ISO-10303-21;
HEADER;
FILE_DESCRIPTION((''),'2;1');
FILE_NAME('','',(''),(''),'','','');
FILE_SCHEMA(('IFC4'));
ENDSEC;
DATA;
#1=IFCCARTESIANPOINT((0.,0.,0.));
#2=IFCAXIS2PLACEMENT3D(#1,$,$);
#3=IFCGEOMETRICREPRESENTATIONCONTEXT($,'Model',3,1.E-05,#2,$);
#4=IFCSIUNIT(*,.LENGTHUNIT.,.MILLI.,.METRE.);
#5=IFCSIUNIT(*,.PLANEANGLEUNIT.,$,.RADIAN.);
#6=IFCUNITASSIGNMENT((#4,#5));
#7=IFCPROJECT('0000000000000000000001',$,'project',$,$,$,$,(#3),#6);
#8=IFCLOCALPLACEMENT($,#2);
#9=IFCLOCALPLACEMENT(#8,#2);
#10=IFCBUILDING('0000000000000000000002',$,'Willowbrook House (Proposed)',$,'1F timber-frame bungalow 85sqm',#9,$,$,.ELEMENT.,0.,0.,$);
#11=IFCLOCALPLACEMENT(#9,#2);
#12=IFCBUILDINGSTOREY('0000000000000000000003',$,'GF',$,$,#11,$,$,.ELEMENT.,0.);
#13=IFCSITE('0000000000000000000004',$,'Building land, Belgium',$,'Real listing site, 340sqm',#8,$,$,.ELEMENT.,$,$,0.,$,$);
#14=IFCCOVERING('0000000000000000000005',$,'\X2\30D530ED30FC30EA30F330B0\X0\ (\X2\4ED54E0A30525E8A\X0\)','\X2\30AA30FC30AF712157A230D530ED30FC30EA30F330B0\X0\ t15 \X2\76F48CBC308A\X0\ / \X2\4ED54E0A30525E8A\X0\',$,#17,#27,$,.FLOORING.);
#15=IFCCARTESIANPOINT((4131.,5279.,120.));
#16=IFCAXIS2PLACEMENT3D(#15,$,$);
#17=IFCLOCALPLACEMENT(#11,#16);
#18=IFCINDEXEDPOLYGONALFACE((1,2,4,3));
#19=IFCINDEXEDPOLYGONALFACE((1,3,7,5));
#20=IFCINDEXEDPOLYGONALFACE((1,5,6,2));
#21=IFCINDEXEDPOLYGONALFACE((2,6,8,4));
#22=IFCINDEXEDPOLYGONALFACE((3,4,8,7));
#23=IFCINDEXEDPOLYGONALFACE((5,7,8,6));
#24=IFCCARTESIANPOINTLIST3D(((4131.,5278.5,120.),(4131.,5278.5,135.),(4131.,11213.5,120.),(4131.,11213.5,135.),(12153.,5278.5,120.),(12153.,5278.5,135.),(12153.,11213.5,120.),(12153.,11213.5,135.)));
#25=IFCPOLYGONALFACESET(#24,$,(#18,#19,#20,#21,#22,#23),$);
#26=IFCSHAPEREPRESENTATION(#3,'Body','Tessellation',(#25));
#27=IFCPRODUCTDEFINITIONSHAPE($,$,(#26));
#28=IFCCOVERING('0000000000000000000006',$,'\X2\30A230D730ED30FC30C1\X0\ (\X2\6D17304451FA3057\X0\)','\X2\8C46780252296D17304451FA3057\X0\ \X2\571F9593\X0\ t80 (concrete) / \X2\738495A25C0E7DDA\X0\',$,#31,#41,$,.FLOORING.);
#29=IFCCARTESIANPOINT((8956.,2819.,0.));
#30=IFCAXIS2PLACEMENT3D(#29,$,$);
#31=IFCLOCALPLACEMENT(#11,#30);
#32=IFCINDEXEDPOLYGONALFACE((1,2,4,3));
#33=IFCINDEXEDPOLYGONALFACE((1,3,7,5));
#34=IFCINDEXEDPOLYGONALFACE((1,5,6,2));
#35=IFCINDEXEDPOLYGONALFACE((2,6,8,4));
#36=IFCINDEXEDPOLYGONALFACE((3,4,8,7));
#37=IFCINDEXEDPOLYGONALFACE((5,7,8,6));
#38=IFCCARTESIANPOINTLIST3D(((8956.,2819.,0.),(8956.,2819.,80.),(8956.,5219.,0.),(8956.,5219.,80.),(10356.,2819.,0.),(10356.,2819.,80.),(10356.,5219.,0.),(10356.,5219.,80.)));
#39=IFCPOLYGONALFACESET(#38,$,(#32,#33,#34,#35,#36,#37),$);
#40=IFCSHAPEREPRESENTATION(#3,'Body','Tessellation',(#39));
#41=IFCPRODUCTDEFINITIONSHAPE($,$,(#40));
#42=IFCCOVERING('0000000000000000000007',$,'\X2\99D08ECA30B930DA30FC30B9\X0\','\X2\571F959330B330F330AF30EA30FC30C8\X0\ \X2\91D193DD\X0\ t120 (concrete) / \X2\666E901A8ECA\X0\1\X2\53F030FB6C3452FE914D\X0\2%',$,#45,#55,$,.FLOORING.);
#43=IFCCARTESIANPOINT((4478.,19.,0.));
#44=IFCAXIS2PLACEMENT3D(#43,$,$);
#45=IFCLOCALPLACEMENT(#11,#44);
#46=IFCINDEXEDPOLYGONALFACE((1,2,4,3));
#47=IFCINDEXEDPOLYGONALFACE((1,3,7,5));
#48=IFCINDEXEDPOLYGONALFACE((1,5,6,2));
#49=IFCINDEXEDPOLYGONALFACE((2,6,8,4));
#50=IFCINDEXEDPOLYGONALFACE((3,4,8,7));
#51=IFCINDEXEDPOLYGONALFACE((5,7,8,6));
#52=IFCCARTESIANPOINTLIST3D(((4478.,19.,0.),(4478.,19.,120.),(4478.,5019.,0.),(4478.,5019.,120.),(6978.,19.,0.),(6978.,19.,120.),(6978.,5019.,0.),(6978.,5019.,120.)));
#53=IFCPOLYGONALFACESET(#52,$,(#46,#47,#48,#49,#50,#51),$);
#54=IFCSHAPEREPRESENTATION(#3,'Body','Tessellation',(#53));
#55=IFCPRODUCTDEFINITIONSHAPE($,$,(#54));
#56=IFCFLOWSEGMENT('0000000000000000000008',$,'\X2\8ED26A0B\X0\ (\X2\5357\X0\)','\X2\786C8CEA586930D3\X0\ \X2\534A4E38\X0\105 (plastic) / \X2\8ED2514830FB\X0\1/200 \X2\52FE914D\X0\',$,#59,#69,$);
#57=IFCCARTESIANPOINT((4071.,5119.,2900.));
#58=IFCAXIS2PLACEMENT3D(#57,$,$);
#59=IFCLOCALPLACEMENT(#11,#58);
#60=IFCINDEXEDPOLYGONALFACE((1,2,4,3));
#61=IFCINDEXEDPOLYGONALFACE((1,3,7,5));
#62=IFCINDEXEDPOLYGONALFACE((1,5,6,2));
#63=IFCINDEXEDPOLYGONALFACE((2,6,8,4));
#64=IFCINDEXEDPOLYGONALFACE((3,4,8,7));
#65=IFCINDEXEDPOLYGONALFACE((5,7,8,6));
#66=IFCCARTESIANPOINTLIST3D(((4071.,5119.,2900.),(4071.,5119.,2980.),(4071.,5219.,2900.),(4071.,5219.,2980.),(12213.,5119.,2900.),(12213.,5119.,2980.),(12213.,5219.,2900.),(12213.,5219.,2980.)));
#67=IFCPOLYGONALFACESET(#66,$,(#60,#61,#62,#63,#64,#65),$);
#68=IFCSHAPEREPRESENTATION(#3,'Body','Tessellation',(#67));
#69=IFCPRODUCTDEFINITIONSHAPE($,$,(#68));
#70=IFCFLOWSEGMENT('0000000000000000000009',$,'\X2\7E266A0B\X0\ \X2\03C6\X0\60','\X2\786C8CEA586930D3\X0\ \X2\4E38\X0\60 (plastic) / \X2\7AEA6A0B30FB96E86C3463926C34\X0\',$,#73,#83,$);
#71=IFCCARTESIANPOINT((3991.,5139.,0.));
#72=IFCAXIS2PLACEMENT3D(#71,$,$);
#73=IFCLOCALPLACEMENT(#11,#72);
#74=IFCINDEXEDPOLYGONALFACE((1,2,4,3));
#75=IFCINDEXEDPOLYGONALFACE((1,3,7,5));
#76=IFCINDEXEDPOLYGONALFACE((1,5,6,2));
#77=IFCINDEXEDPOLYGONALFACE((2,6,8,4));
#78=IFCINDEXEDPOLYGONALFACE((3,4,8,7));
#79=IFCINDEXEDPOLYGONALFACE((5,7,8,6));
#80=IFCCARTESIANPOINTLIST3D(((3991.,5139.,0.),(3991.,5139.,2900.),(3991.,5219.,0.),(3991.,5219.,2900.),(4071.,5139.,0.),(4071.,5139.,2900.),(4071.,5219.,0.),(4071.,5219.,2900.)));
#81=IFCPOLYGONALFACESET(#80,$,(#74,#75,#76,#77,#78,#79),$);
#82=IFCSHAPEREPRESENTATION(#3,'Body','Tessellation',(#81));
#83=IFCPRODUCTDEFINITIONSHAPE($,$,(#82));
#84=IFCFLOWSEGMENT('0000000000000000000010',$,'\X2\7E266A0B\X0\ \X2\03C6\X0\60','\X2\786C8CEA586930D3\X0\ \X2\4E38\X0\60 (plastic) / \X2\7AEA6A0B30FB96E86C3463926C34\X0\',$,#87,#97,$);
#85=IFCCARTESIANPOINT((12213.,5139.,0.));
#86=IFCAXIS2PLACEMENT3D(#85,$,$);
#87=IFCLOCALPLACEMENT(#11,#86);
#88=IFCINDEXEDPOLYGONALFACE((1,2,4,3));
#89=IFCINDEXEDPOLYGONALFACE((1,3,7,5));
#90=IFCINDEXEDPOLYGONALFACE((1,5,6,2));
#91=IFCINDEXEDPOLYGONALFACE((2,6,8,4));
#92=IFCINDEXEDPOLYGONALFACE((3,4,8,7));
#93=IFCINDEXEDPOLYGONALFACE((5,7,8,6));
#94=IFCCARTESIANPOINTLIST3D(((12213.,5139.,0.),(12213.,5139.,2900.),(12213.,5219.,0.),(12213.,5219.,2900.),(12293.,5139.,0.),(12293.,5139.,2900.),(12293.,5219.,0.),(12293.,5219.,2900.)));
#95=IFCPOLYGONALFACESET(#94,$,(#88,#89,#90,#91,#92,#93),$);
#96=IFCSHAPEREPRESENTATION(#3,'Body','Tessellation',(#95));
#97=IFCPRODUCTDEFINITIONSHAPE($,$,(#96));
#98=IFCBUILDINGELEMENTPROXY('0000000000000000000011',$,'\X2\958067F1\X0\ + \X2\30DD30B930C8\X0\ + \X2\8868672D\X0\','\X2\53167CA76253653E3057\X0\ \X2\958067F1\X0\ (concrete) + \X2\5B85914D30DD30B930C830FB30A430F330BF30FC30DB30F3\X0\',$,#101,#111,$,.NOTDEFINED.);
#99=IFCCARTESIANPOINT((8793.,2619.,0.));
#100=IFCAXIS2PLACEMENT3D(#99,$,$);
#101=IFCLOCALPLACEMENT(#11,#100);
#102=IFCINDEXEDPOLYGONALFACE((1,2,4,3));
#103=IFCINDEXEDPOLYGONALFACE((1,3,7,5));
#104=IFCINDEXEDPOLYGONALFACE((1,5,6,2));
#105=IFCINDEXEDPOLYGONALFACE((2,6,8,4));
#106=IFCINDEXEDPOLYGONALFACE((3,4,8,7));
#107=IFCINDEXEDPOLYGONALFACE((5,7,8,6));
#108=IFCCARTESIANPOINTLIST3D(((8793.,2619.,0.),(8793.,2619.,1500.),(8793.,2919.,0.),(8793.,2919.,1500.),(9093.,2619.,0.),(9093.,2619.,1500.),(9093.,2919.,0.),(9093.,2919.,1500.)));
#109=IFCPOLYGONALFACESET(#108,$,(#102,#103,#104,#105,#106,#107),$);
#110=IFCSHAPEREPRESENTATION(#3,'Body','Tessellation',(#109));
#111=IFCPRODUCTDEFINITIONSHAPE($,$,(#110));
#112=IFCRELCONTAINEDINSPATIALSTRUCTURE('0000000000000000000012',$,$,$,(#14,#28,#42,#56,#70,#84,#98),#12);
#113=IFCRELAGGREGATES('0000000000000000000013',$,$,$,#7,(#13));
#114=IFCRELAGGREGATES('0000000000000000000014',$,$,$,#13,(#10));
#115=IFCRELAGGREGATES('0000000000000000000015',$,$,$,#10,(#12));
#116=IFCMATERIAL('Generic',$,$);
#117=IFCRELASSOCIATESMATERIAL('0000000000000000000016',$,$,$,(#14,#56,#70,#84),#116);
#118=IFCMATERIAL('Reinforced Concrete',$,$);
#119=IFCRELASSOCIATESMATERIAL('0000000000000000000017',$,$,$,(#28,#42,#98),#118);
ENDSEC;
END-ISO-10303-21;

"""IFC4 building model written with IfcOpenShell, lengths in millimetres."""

from ifc_helpers import new_model, si_unit, frame, frame_2d, origin, place, context, project, spatial, rectangle, extrude, material, element, save


model = new_model("IFC4")

# Units and contexts
model_context = context("Model", 3, precision=1e-05, world=origin())
ifc_project = project(units=[si_unit("LENGTHUNIT", "METRE", prefix="MILLI"), si_unit("PLANEANGLEUNIT", "RADIAN")], contexts=[model_context])

# Site, building, storey
site_placement = place(None, origin())
site = spatial("IfcSite", under=ifc_project, at=site_placement, Name="Building land, Belgium", ObjectType="Real listing site, 340sqm", CompositionType="ELEMENT", RefElevation=0.0)
building_placement = place(site_placement, origin())
building = spatial("IfcBuilding", under=site, at=building_placement, Name="Willowbrook House (Proposed)", ObjectType="1F timber-frame bungalow 85sqm", CompositionType="ELEMENT", ElevationOfRefHeight=0.0, ElevationOfTerrain=0.0)
storey_placement = place(building_placement, origin())
storey = spatial("IfcBuildingStorey", under=building, at=storey_placement, Name="GF", CompositionType="ELEMENT", Elevation=0.0)

# Shared definitions
ifc_material_1 = material(Name="Reinforced Concrete")

# Coverings
ifc_material_2 = material(Name="Generic")
covering_1_placement = place(storey_placement, frame((4131.0, 5279.0, 120.0)))
element("IfcCovering", 1, at=covering_1_placement, inside=storey, material=ifc_material_2, Name="フローリング (仕上げ床)", Description="オーク無垢フローリング t15 直貼り / 仕上げ床", PredefinedType="FLOORING", context=model_context, shape_type="SweptSolid", body=[
    extrude(rectangle(XDim=8022.0, YDim=5935.0, at=frame_2d((4011.0, 2967.0))), frame((4131.0, 5279.0, 120.0)), (0.0, 0.0, 1.0), 15.0),
])
covering_2_placement = place(storey_placement, frame((8956.0, 2819.0, 0.0)))
element("IfcCovering", 2, at=covering_2_placement, inside=storey, material=ifc_material_1, Name="アプローチ (洗い出し)", Description="豆砂利洗い出し 土間 t80 (concrete) / 玄関導線", PredefinedType="FLOORING", context=model_context, shape_type="SweptSolid", body=[
    extrude(rectangle(XDim=1400.0, YDim=2400.0, at=frame_2d((700.0, 1200.0))), frame((8956.0, 2819.0, 0.0)), (0.0, 0.0, 1.0), 80.0),
])
covering_3_placement = place(storey_placement, frame((4478.0, 19.0, 0.0)))
element("IfcCovering", 3, at=covering_3_placement, inside=storey, material=ifc_material_1, Name="駐車スペース", Description="土間コンクリート 金鏝 t120 (concrete) / 普通車1台・水勾配2%", PredefinedType="FLOORING", context=model_context, shape_type="SweptSolid", body=[
    extrude(rectangle(XDim=2500.0, YDim=5000.0, at=frame_2d((1250.0, 2500.0))), frame((4478.0, 19.0, 0.0)), (0.0, 0.0, 1.0), 120.0),
])

# Flow segments
flow_segment_1_placement = place(storey_placement, frame((4071.0, 5119.0, 2900.0)))
element("IfcFlowSegment", 4, at=flow_segment_1_placement, inside=storey, material=ifc_material_2, Name="軒樋 (南)", Description="硬質塩ビ 半丸105 (plastic) / 軒先・1/200 勾配", context=model_context, shape_type="SweptSolid", body=[
    extrude(rectangle(XDim=8142.0, YDim=100.0, at=frame_2d((4071.0, 50.0))), frame((4071.0, 5119.0, 2900.0)), (0.0, 0.0, 1.0), 80.0),
])
flow_segment_2_placement = place(storey_placement, frame((3991.0, 5139.0, 0.0)))
element("IfcFlowSegment", 5, at=flow_segment_2_placement, inside=storey, material=ifc_material_2, Name="縦樋 φ60", Description="硬質塩ビ 丸60 (plastic) / 竪樋・雨水排水", context=model_context, shape_type="SweptSolid", body=[
    extrude(rectangle(XDim=80.0, YDim=80.0, at=frame_2d((40.0, 40.0))), frame((3991.0, 5139.0, 0.0)), (0.0, 0.0, 1.0), 2900.0),
])
flow_segment_3_placement = place(storey_placement, frame((12213.0, 5139.0, 0.0)))
element("IfcFlowSegment", 6, at=flow_segment_3_placement, inside=storey, material=ifc_material_2, Name="縦樋 φ60", Description="硬質塩ビ 丸60 (plastic) / 竪樋・雨水排水", context=model_context, shape_type="SweptSolid", body=[
    extrude(rectangle(XDim=80.0, YDim=80.0, at=frame_2d((40.0, 40.0))), frame((12213.0, 5139.0, 0.0)), (0.0, 0.0, 1.0), 2900.0),
])

# Building element proxy
proxy_placement = place(storey_placement, frame((8793.0, 2619.0, 0.0)))
element("IfcBuildingElementProxy", 7, at=proxy_placement, inside=storey, material=ifc_material_1, Name="門柱 + ポスト + 表札", Description="化粧打放し 門柱 (concrete) + 宅配ポスト・インターホン", PredefinedType="NOTDEFINED", context=model_context, shape_type="SweptSolid", body=[
    extrude(rectangle(XDim=300.0, YDim=300.0, at=frame_2d((150.0, 150.0))), frame((8793.0, 2619.0, 0.0)), (0.0, 0.0, 1.0), 1500.0),
])

save(model, "model.ifc")
